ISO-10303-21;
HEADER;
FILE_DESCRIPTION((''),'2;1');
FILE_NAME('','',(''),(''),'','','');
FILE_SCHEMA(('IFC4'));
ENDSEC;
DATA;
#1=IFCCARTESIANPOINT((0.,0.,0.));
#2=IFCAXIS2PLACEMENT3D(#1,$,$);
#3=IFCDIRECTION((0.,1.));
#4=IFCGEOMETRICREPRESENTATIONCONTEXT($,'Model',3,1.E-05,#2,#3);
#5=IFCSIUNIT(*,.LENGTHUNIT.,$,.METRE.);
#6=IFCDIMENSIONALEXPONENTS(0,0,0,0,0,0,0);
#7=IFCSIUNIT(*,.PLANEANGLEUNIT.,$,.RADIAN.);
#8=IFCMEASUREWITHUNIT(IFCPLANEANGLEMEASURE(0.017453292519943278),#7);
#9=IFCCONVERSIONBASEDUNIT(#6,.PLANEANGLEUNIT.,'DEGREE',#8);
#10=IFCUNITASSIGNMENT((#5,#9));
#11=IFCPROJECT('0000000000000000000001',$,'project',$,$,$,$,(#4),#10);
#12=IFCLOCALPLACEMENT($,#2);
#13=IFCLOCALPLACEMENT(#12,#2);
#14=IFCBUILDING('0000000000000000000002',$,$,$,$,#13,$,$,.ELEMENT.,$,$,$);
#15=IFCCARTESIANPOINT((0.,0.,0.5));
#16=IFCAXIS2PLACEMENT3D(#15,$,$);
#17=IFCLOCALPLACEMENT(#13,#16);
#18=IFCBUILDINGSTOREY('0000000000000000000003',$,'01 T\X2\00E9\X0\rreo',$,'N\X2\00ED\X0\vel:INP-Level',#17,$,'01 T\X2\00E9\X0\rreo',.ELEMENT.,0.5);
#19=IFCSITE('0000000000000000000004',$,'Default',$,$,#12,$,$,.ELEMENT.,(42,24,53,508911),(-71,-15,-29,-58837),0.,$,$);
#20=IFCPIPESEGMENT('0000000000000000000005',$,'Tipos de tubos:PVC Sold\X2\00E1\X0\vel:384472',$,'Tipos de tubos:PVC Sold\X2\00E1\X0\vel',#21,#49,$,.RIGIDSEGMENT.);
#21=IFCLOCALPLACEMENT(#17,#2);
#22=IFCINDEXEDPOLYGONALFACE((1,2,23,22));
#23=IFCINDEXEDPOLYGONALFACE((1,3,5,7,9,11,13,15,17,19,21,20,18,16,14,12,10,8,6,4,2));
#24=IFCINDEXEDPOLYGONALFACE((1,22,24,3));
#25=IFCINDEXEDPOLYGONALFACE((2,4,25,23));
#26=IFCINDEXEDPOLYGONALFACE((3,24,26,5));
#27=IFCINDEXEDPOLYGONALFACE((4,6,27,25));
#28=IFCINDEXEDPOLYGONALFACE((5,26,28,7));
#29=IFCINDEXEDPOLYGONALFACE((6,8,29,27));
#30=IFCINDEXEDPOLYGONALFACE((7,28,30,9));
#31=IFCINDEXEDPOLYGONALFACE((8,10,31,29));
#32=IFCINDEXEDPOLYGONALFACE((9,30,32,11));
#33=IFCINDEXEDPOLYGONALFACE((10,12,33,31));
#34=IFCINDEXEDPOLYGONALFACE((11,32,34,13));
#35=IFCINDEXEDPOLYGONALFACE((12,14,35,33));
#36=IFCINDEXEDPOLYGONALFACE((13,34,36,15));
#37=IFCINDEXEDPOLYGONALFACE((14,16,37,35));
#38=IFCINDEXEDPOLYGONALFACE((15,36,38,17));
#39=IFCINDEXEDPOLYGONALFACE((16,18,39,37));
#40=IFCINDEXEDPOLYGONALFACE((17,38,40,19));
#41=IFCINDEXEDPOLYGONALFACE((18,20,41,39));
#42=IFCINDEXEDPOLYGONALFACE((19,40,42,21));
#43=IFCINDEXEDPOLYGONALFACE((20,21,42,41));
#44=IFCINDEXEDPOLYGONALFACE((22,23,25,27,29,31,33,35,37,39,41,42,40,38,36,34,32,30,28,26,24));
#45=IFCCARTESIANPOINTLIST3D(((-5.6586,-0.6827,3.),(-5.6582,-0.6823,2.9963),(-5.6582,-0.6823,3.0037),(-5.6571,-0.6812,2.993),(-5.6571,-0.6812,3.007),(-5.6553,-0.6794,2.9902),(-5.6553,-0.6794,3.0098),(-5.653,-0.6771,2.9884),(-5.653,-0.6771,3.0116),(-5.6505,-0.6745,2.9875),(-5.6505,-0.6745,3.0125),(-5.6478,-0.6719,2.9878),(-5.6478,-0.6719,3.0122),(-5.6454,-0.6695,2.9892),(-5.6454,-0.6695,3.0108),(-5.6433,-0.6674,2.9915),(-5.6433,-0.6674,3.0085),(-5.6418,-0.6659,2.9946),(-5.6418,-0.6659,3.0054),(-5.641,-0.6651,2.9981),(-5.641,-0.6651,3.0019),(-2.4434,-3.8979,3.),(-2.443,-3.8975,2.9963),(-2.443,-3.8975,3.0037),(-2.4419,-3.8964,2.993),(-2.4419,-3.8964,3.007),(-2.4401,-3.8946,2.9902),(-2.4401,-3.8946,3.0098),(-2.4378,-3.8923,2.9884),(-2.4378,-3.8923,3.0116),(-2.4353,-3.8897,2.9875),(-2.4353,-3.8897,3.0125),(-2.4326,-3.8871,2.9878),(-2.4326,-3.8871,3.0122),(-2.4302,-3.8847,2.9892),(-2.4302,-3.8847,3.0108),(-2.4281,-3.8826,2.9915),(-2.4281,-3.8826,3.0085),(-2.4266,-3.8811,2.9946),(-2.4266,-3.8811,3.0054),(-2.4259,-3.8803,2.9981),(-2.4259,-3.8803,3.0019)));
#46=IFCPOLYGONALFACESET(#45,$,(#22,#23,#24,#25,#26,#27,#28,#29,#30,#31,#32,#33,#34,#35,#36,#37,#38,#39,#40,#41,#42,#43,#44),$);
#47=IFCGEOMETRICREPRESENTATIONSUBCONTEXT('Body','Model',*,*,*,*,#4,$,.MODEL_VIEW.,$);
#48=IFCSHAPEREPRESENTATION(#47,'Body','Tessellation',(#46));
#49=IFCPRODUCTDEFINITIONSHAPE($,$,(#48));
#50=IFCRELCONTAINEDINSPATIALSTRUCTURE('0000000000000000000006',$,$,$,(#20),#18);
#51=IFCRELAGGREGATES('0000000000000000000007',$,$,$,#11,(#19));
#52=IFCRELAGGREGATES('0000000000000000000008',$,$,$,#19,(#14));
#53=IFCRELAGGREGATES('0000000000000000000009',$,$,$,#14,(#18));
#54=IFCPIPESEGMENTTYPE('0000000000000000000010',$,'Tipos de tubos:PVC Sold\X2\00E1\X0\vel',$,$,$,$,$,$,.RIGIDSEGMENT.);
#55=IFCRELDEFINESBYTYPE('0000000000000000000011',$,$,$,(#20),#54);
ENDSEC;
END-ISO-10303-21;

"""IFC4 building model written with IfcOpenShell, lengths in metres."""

from ifc_helpers import new_model, entity, si_unit, converted_unit, direction, frame, origin, origin_2d_with_axis, place, context, subcontext, project, spatial, circle, extrude, type_object, element, save


model = new_model("IFC4")

# Units and contexts
model_context = context("Model", 3, precision=1e-05, world=origin(), true_north=direction((0.0, 1.0)))
body_context = subcontext(model_context, "Body", "Model", "MODEL_VIEW")
ifc_project = project(units=[si_unit("LENGTHUNIT", "METRE"), converted_unit("PLANEANGLEUNIT", "DEGREE", entity("IfcPlaneAngleMeasure", 0.017453292519943278), si_unit("PLANEANGLEUNIT", "RADIAN"), dimensions=[0, 0, 0, 0, 0, 0, 0])], contexts=[model_context])

# Site, building, storey
site_placement = place(None, origin())
site = spatial("IfcSite", under=ifc_project, at=site_placement, Name="Default", CompositionType="ELEMENT", RefLatitude=(42, 24, 53, 508911), RefLongitude=(-71, -15, -29, -58837), RefElevation=0.0)
building_placement = place(site_placement, origin())
building = spatial("IfcBuilding", under=site, at=building_placement, CompositionType="ELEMENT")
storey_placement = place(building_placement, frame((0.0, 0.0, 0.5)))
storey = spatial("IfcBuildingStorey", under=building, at=storey_placement, Name="01 Térreo", ObjectType="Nível:INP-Level", LongName="01 Térreo", CompositionType="ELEMENT", Elevation=0.5)

# Pipe segment
pipe_segment_type = type_object("IfcPipeSegmentType", Name="Tipos de tubos:PVC Soldável", PredefinedType="RIGIDSEGMENT")
pipe_segment_1_placement = place(storey_placement, frame((-5.6602, -3.8995, 3.0141)))
element("IfcPipeSegment", 1, at=pipe_segment_1_placement, inside=storey, type_object=pipe_segment_type, Name="Tipos de tubos:PVC Soldável:384472", ObjectType="Tipos de tubos:PVC Soldável", PredefinedType="RIGIDSEGMENT", context=body_context, shape_type="SweptSolid", body=[
    extrude(circle(Radius=0.0125, at=origin_2d_with_axis()), frame((3.2256, 0.0104, -0.0141), z_axis=(-0.707107, 0.707107, 0.0), x_axis=(-0.707107, -0.707107, 0.0)), (0.0, 0.0, 1.0), 4.547),
])

save(model, "model.ifc")
